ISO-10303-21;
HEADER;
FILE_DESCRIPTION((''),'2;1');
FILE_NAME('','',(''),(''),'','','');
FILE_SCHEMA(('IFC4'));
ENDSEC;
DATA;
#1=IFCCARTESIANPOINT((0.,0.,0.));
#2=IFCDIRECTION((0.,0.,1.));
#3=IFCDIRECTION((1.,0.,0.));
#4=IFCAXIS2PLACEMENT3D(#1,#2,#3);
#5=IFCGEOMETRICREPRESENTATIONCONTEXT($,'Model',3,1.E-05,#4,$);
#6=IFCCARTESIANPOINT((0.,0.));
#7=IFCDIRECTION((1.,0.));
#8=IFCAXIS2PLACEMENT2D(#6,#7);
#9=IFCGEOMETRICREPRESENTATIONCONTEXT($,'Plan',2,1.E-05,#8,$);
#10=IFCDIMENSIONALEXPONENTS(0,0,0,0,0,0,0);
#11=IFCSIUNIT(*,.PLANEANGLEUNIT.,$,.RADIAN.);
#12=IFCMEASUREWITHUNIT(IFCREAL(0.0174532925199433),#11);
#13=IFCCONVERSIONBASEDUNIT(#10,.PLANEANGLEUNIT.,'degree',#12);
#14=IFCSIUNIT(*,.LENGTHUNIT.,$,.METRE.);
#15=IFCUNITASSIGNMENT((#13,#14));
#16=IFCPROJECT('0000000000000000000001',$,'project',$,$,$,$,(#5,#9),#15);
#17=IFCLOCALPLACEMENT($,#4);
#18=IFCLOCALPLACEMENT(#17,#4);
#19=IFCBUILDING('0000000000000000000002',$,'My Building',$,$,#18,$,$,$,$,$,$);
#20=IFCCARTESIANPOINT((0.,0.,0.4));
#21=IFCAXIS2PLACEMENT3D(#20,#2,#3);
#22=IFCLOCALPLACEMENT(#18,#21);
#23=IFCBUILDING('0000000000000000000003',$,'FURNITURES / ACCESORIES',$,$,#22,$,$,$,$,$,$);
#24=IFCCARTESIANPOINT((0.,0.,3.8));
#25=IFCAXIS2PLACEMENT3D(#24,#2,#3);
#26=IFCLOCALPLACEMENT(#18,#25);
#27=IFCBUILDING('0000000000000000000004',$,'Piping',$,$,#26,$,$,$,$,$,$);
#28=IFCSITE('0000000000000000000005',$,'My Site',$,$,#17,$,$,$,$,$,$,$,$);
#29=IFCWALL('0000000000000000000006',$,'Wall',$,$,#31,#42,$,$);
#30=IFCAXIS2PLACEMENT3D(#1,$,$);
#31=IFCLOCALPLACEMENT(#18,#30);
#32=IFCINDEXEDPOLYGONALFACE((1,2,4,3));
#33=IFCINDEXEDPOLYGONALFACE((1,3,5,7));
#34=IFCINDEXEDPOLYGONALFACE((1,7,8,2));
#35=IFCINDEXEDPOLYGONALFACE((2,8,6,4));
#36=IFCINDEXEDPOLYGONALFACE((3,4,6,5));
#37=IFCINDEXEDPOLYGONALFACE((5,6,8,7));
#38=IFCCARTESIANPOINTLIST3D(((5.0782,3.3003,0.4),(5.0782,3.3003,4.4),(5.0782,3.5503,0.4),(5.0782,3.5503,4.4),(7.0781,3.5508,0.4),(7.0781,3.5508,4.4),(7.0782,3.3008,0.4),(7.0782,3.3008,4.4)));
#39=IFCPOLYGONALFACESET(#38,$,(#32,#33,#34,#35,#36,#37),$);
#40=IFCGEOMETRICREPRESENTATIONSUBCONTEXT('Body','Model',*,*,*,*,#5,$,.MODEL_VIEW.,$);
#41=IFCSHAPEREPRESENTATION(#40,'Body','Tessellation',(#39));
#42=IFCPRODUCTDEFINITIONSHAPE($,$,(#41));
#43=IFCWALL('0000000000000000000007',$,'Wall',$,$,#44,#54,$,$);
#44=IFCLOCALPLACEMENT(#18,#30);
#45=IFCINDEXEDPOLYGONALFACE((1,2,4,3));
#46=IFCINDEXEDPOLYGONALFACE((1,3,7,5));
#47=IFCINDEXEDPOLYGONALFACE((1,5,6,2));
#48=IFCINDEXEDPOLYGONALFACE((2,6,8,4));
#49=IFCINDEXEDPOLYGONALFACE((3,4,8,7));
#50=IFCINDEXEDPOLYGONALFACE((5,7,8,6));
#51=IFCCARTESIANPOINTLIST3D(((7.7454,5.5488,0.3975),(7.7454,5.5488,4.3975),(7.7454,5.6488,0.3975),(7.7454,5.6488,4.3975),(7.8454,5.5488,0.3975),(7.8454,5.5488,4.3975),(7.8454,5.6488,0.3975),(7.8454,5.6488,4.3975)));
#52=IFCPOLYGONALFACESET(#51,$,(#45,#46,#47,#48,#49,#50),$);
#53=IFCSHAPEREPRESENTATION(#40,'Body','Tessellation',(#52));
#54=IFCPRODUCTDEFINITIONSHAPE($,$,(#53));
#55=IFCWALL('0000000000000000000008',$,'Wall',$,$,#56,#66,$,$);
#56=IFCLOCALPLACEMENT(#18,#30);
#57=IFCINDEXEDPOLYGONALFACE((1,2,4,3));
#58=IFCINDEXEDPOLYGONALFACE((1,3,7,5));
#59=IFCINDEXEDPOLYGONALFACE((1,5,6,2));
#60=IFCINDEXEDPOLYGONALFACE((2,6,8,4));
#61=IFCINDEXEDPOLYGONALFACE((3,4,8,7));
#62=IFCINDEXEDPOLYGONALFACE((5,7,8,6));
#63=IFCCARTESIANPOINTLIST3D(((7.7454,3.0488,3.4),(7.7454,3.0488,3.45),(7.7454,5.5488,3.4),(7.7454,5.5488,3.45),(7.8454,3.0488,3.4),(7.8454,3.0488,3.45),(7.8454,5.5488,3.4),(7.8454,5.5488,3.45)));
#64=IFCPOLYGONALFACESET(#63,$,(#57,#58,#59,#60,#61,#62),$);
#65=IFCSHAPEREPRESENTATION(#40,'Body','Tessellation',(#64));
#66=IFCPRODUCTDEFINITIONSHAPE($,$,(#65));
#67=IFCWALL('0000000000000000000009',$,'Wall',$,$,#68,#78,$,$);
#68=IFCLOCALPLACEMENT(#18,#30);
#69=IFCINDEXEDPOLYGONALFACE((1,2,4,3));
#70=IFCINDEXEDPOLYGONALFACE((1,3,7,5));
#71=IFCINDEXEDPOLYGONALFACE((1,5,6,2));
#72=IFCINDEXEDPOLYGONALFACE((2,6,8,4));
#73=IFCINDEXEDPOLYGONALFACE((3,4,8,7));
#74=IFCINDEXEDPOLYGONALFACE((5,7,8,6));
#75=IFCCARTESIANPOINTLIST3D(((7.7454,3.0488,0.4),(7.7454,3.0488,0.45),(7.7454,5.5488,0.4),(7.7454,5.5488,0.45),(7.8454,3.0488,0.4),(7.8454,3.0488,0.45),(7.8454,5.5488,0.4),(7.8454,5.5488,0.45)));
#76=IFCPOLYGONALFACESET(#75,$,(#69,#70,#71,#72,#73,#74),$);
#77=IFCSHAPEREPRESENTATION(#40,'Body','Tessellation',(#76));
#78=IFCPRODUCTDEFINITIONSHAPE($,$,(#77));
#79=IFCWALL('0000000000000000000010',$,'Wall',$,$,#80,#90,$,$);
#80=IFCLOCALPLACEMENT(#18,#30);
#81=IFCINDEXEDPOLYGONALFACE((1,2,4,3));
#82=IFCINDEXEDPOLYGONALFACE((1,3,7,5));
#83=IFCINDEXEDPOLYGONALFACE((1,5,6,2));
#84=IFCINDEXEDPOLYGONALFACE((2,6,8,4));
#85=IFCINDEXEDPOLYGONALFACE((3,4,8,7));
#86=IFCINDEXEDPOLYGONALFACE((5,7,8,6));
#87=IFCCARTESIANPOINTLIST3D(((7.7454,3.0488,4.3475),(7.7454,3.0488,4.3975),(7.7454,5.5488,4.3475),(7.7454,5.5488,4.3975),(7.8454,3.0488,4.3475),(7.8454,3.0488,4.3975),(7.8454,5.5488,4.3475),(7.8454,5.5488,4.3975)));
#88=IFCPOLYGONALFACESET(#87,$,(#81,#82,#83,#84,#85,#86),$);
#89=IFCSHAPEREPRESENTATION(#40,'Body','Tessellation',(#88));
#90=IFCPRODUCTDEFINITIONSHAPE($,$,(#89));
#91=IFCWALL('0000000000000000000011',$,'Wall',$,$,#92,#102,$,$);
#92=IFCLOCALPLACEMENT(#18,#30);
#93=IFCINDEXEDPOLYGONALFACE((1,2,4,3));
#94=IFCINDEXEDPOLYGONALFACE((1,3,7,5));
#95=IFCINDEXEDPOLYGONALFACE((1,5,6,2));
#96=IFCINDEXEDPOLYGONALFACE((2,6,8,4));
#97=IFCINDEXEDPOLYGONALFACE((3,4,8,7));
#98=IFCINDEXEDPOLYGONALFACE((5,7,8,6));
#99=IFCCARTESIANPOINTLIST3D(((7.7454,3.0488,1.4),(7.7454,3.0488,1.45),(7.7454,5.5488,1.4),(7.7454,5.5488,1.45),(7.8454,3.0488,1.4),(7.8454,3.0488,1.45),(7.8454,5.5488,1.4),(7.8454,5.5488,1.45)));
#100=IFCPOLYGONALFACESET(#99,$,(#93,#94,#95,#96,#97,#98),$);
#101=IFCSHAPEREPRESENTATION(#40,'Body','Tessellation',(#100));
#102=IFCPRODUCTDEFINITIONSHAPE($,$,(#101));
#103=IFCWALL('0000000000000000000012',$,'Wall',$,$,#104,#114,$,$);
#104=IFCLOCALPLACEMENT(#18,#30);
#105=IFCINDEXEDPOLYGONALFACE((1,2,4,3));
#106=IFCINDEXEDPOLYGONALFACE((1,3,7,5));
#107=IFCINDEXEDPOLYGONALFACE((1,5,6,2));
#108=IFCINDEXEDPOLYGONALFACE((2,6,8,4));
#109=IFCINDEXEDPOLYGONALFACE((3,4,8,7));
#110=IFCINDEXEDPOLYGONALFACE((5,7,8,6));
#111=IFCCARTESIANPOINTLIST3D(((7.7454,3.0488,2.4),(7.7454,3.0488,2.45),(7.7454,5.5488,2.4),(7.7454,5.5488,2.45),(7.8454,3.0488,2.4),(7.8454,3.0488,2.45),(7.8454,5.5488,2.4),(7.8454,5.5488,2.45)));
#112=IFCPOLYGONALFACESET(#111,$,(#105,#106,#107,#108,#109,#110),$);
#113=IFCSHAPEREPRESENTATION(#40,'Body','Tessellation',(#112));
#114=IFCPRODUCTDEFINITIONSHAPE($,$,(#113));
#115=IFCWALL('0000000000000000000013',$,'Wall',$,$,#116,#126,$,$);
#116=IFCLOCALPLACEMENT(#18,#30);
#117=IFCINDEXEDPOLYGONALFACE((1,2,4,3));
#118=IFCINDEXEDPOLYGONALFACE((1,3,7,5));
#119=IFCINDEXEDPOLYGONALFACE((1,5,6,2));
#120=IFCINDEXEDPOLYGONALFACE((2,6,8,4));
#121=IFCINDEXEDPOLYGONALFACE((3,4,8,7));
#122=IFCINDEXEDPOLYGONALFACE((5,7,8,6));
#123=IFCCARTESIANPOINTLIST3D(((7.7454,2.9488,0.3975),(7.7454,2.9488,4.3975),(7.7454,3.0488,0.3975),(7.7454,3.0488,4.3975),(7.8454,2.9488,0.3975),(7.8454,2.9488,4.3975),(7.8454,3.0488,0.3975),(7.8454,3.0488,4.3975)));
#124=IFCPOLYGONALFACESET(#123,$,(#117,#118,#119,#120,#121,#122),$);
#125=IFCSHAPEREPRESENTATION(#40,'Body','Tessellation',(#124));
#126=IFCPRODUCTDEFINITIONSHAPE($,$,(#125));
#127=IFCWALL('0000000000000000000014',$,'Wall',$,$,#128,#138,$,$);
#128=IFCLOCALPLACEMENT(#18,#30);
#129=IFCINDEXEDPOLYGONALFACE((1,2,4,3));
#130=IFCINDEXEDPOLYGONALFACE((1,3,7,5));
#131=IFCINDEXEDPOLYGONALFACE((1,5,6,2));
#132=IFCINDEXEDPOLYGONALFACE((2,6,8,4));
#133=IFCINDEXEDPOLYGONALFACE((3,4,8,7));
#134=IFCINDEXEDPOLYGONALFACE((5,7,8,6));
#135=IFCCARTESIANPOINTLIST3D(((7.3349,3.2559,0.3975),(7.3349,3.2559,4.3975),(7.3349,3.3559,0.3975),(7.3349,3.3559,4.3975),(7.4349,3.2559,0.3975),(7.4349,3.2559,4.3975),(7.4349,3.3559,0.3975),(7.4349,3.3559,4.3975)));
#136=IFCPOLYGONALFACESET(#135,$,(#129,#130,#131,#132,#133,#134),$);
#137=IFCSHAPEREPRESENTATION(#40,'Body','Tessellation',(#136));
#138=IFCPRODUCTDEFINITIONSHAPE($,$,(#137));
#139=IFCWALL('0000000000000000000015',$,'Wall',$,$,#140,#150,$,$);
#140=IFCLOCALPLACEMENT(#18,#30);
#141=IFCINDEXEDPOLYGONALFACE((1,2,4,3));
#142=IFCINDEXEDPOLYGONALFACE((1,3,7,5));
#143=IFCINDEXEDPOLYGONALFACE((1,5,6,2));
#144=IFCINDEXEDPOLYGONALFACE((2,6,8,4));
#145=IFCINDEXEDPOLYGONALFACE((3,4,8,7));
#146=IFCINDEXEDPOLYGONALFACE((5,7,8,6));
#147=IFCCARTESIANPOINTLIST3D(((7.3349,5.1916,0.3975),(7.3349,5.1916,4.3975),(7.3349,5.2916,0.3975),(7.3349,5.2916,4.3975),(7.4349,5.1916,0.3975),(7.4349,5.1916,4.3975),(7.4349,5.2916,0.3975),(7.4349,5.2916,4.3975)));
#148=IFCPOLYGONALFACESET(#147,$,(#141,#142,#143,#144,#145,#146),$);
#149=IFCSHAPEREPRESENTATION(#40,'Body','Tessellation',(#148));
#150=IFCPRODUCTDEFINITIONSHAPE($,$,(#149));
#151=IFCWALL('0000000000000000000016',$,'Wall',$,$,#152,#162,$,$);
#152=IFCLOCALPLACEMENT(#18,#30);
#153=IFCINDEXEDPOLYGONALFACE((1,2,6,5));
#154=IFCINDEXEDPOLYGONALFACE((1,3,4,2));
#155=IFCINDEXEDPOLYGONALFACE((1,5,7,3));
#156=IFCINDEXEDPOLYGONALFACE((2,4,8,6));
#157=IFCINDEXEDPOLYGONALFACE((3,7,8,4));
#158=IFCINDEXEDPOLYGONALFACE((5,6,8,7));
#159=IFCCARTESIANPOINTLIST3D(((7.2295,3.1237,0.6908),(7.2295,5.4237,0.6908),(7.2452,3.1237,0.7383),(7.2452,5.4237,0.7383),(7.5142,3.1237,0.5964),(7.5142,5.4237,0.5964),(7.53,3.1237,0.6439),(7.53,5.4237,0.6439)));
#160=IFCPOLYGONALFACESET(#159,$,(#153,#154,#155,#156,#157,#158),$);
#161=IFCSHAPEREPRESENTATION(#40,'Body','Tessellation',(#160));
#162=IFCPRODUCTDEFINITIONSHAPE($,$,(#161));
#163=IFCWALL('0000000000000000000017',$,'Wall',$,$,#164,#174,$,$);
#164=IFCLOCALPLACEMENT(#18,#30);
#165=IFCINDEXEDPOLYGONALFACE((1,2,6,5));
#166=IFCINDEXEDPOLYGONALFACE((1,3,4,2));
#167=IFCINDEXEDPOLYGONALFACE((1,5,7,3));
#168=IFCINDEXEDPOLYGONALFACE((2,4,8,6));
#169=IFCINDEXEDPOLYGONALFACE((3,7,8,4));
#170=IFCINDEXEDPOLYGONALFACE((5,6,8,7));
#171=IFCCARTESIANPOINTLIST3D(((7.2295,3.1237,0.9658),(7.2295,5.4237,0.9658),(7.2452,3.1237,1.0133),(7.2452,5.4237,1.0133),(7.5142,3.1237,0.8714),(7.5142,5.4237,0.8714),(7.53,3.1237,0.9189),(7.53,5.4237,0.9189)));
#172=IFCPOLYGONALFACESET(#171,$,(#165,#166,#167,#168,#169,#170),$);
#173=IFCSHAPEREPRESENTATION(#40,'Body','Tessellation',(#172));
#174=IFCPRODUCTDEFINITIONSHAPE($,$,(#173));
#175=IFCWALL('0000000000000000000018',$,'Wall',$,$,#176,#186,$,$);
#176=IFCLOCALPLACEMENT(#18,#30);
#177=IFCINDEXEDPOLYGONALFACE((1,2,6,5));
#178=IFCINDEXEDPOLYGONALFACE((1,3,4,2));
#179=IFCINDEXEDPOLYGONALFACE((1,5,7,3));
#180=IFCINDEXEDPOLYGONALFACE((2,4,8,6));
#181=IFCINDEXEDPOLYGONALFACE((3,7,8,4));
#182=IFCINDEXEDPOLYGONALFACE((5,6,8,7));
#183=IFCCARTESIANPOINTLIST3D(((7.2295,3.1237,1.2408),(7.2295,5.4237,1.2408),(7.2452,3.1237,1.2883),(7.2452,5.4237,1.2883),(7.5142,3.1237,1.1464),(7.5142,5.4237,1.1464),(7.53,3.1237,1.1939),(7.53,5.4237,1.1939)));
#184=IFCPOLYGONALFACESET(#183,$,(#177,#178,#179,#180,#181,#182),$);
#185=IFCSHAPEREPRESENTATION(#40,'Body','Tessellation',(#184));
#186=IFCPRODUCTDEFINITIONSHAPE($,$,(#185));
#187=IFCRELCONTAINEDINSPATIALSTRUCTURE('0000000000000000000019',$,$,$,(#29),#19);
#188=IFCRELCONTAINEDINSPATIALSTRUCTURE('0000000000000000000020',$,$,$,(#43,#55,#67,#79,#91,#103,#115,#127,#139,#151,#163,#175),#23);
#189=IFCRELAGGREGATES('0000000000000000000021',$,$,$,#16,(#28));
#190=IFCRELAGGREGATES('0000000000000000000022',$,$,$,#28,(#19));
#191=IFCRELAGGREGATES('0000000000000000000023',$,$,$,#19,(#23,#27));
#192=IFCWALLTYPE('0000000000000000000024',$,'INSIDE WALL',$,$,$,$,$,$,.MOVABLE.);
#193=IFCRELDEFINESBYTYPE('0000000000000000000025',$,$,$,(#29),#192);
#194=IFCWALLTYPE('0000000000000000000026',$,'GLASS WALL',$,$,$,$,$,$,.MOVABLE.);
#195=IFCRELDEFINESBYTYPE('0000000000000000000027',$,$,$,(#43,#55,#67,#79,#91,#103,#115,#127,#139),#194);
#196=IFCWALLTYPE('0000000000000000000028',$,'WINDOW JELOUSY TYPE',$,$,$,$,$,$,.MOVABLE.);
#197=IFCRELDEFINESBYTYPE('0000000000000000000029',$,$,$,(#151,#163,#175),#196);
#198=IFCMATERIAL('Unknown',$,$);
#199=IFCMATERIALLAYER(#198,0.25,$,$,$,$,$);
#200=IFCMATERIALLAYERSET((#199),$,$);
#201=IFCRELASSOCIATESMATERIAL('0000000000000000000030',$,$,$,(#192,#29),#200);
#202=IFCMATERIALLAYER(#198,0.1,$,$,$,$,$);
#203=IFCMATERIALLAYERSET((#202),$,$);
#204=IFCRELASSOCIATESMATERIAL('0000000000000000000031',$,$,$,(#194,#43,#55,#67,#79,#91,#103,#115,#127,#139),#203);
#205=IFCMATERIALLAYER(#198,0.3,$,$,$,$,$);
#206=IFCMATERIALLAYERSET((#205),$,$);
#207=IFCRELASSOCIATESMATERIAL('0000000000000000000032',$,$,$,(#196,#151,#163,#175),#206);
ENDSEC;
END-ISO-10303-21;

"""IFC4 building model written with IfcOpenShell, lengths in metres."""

from ifc_helpers import new_model, entity, si_unit, converted_unit, frame, origin_with_axes, origin_2d_with_axis, place, context, subcontext, project, spatial, line, indexed_curve, outline, extrude, material, layer, layer_set, layer_usage, type_object, element, save


model = new_model("IFC4")

# Units and contexts
model_context = context("Model", 3, precision=1e-05, world=origin_with_axes())
plan_context = context("Plan", 2, precision=1e-05, world=origin_2d_with_axis())
body_context = subcontext(model_context, "Body", "Model", "MODEL_VIEW")
ifc_project = project(units=[converted_unit("PLANEANGLEUNIT", "degree", entity("IfcReal", 0.0174532925199433), si_unit("PLANEANGLEUNIT", "RADIAN"), dimensions=[0, 0, 0, 0, 0, 0, 0]), si_unit("LENGTHUNIT", "METRE")], contexts=[model_context, plan_context])

# Site, building
site_placement = place(None, origin_with_axes())
site = spatial("IfcSite", under=ifc_project, at=site_placement, Name="My Site")
building_1_placement = place(site_placement, origin_with_axes())
building_1 = spatial("IfcBuilding", under=site, at=building_1_placement, Name="My Building")

# Wall
ifc_material = material(Name="Unknown")
ifc_layer_1 = layer(ifc_material, 0.25)
ifc_layer_set_1 = layer_set([ifc_layer_1])
ifc_layer_usage_1 = layer_usage(ifc_layer_set_1, "AXIS2", "POSITIVE", 0.0)
wall_type_1 = type_object("IfcWallType", Name="INSIDE WALL", PredefinedType="MOVABLE", material=ifc_layer_set_1)
wall_1_placement = place(building_1_placement, frame((7.0781, 3.5508, 0.4), z_axis=(0.0, 0.0, 1.0), x_axis=(-1.0, -0.000252, 0.0)))
element("IfcWall", 1, at=wall_1_placement, inside=building_1, type_object=wall_type_1, material=ifc_layer_usage_1, Name="Wall", context=body_context, shape_type="SweptSolid", body=[
    extrude(outline(indexed_curve([(0.0, 0.0), (0.0, 0.25), (2.0, 0.25), (2.0, 0.0)], segments=[line(1, 2, 3, 4, 1)])), origin_with_axes(), (0.0, 0.0, 1.0), 4.0),
])

# Shared definitions
building_2_placement = place(building_1_placement, frame((0.0, 0.0, 0.4), z_axis=(0.0, 0.0, 1.0), x_axis=(1.0, 0.0, 0.0)))
building_2 = spatial("IfcBuilding", under=building_1, at=building_2_placement, Name="FURNITURES / ACCESORIES")

# Walls
ifc_layer_2 = layer(ifc_material, 0.1)
ifc_layer_set_2 = layer_set([ifc_layer_2])
ifc_layer_usage_2 = layer_usage(ifc_layer_set_2, "AXIS2", "POSITIVE", 0.0)
wall_type_2 = type_object("IfcWallType", Name="GLASS WALL", PredefinedType="MOVABLE", material=ifc_layer_set_2)
wall_2_placement = place(building_2_placement, frame((7.7454, 5.6488, -0.0025), z_axis=(0.0, 0.0, 1.0), x_axis=(0.0, -1.0, 0.0)))
element("IfcWall", 2, at=wall_2_placement, inside=building_2, type_object=wall_type_2, material=ifc_layer_usage_2, Name="Wall", context=body_context, shape_type="SweptSolid", body=[
    extrude(outline(indexed_curve([(0.0, 0.0), (0.0, 0.1), (0.1, 0.1), (0.1, 0.0)], segments=[line(1, 2, 3, 4, 1)])), origin_with_axes(), (0.0, 0.0, 1.0), 4.0),
])
ifc_layer_usage_3 = layer_usage(ifc_layer_set_2, "AXIS2", "POSITIVE", 0.0)
wall_3_placement = place(building_2_placement, frame((7.7454, 5.5488, 3.0), z_axis=(0.0, 0.0, 1.0), x_axis=(0.0, -1.0, 0.0)))
element("IfcWall", 3, at=wall_3_placement, inside=building_2, type_object=wall_type_2, material=ifc_layer_usage_3, Name="Wall", context=body_context, shape_type="SweptSolid", body=[
    extrude(outline(indexed_curve([(0.0, 0.0), (0.0, 0.1), (2.5, 0.1), (2.5, 0.0)], segments=[line(1, 2, 3, 4, 1)])), origin_with_axes(), (0.0, 0.0, 1.0), 0.05),
])
ifc_layer_usage_4 = layer_usage(ifc_layer_set_2, "AXIS2", "POSITIVE", 0.0)
wall_4_placement = place(building_2_placement, frame((7.7454, 5.5488, 0.0), z_axis=(0.0, 0.0, 1.0), x_axis=(0.0, -1.0, 0.0)))
element("IfcWall", 4, at=wall_4_placement, inside=building_2, type_object=wall_type_2, material=ifc_layer_usage_4, Name="Wall", context=body_context, shape_type="SweptSolid", body=[
    extrude(outline(indexed_curve([(0.0, 0.0), (0.0, 0.1), (2.5, 0.1), (2.5, 0.0)], segments=[line(1, 2, 3, 4, 1)])), origin_with_axes(), (0.0, 0.0, 1.0), 0.05),
])
ifc_layer_usage_5 = layer_usage(ifc_layer_set_2, "AXIS2", "POSITIVE", 0.0)
wall_5_placement = place(building_2_placement, frame((7.7454, 5.5488, 3.9475), z_axis=(0.0, 0.0, 1.0), x_axis=(0.0, -1.0, 0.0)))
element("IfcWall", 5, at=wall_5_placement, inside=building_2, type_object=wall_type_2, material=ifc_layer_usage_5, Name="Wall", context=body_context, shape_type="SweptSolid", body=[
    extrude(outline(indexed_curve([(0.0, 0.0), (0.0, 0.1), (2.5, 0.1), (2.5, 0.0)], segments=[line(1, 2, 3, 4, 1)])), origin_with_axes(), (0.0, 0.0, 1.0), 0.05),
])
ifc_layer_usage_6 = layer_usage(ifc_layer_set_2, "AXIS2", "POSITIVE", 0.0)
wall_6_placement = place(building_2_placement, frame((7.7454, 5.5488, 1.0), z_axis=(0.0, 0.0, 1.0), x_axis=(0.0, -1.0, 0.0)))
element("IfcWall", 6, at=wall_6_placement, inside=building_2, type_object=wall_type_2, material=ifc_layer_usage_6, Name="Wall", context=body_context, shape_type="SweptSolid", body=[
    extrude(outline(indexed_curve([(0.0, 0.0), (0.0, 0.1), (2.5, 0.1), (2.5, 0.0)], segments=[line(1, 2, 3, 4, 1)])), origin_with_axes(), (0.0, 0.0, 1.0), 0.05),
])
ifc_layer_usage_7 = layer_usage(ifc_layer_set_2, "AXIS2", "POSITIVE", 0.0)
wall_7_placement = place(building_2_placement, frame((7.7454, 5.5488, 2.0), z_axis=(0.0, 0.0, 1.0), x_axis=(0.0, -1.0, 0.0)))
element("IfcWall", 7, at=wall_7_placement, inside=building_2, type_object=wall_type_2, material=ifc_layer_usage_7, Name="Wall", context=body_context, shape_type="SweptSolid", body=[
    extrude(outline(indexed_curve([(0.0, 0.0), (0.0, 0.1), (2.5, 0.1), (2.5, 0.0)], segments=[line(1, 2, 3, 4, 1)])), origin_with_axes(), (0.0, 0.0, 1.0), 0.05),
])
ifc_layer_usage_8 = layer_usage(ifc_layer_set_2, "AXIS2", "POSITIVE", 0.0)
wall_8_placement = place(building_2_placement, frame((7.7454, 2.9488, -0.0025), z_axis=(0.0, 0.0, 1.0), x_axis=(1.0, 0.0, 0.0)))
element("IfcWall", 8, at=wall_8_placement, inside=building_2, type_object=wall_type_2, material=ifc_layer_usage_8, Name="Wall", context=body_context, shape_type="SweptSolid", body=[
    extrude(outline(indexed_curve([(0.0, 0.0), (0.0, 0.1), (0.1, 0.1), (0.1, 0.0)], segments=[line(1, 2, 3, 4, 1)])), origin_with_axes(), (0.0, 0.0, 1.0), 4.0),
])
ifc_layer_usage_9 = layer_usage(ifc_layer_set_2, "AXIS2", "POSITIVE", 0.0)
wall_9_placement = place(building_2_placement, frame((7.3349, 3.2559, -0.0025), z_axis=(0.0, 0.0, 1.0), x_axis=(1.0, 0.0, 0.0)))
element("IfcWall", 9, at=wall_9_placement, inside=building_2, type_object=wall_type_2, material=ifc_layer_usage_9, Name="Wall", context=body_context, shape_type="SweptSolid", body=[
    extrude(outline(indexed_curve([(0.0, 0.0), (0.0, 0.1), (0.1, 0.1), (0.1, 0.0)], segments=[line(1, 2, 3, 4, 1)])), origin_with_axes(), (0.0, 0.0, 1.0), 4.0),
])
ifc_layer_usage_10 = layer_usage(ifc_layer_set_2, "AXIS2", "POSITIVE", 0.0)
wall_10_placement = place(building_2_placement, frame((7.3349, 5.1916, -0.0025), z_axis=(0.0, 0.0, 1.0), x_axis=(1.0, 0.0, 0.0)))
element("IfcWall", 10, at=wall_10_placement, inside=building_2, type_object=wall_type_2, material=ifc_layer_usage_10, Name="Wall", context=body_context, shape_type="SweptSolid", body=[
    extrude(outline(indexed_curve([(0.0, 0.0), (0.0, 0.1), (0.1, 0.1), (0.1, 0.0)], segments=[line(1, 2, 3, 4, 1)])), origin_with_axes(), (0.0, 0.0, 1.0), 4.0),
])
ifc_layer_3 = layer(ifc_material, 0.3)
ifc_layer_set_3 = layer_set([ifc_layer_3])
ifc_layer_usage_11 = layer_usage(ifc_layer_set_3, "AXIS2", "POSITIVE", 0.0)
wall_type_3 = type_object("IfcWallType", Name="WINDOW JELOUSY TYPE", PredefinedType="MOVABLE", material=ifc_layer_set_3)
wall_11_placement = place(building_2_placement, frame((7.2295, 5.4237, 0.2908), z_axis=(0.314762, 0.0, 0.949171), x_axis=(0.0, -1.0, 0.0)))
element("IfcWall", 11, at=wall_11_placement, inside=building_2, type_object=wall_type_3, material=ifc_layer_usage_11, Name="Wall", context=body_context, shape_type="SweptSolid", body=[
    extrude(outline(indexed_curve([(0.0, 0.0), (0.0, 0.3), (2.3, 0.3), (2.3, 0.0)], segments=[line(1, 2, 3, 4, 1)])), origin_with_axes(), (0.0, 0.0, 1.0), 0.05),
])
ifc_layer_usage_12 = layer_usage(ifc_layer_set_3, "AXIS2", "POSITIVE", 0.0)
wall_12_placement = place(building_2_placement, frame((7.2295, 5.4237, 0.5658), z_axis=(0.314762, 0.0, 0.949171), x_axis=(0.0, -1.0, 0.0)))
element("IfcWall", 12, at=wall_12_placement, inside=building_2, type_object=wall_type_3, material=ifc_layer_usage_12, Name="Wall", context=body_context, shape_type="SweptSolid", body=[
    extrude(outline(indexed_curve([(0.0, 0.0), (0.0, 0.3), (2.3, 0.3), (2.3, 0.0)], segments=[line(1, 2, 3, 4, 1)])), origin_with_axes(), (0.0, 0.0, 1.0), 0.05),
])
ifc_layer_usage_13 = layer_usage(ifc_layer_set_3, "AXIS2", "POSITIVE", 0.0)
wall_13_placement = place(building_2_placement, frame((7.2295, 5.4237, 0.8408), z_axis=(0.314762, 0.0, 0.949171), x_axis=(0.0, -1.0, 0.0)))
element("IfcWall", 13, at=wall_13_placement, inside=building_2, type_object=wall_type_3, material=ifc_layer_usage_13, Name="Wall", context=body_context, shape_type="SweptSolid", body=[
    extrude(outline(indexed_curve([(0.0, 0.0), (0.0, 0.3), (2.3, 0.3), (2.3, 0.0)], segments=[line(1, 2, 3, 4, 1)])), origin_with_axes(), (0.0, 0.0, 1.0), 0.05),
])

# Shared definitions
building_3_placement = place(building_1_placement, frame((0.0, 0.0, 3.8), z_axis=(0.0, 0.0, 1.0), x_axis=(1.0, 0.0, 0.0)))
building_3 = spatial("IfcBuilding", under=building_1, at=building_3_placement, Name="Piping")

save(model, "model.ifc")
